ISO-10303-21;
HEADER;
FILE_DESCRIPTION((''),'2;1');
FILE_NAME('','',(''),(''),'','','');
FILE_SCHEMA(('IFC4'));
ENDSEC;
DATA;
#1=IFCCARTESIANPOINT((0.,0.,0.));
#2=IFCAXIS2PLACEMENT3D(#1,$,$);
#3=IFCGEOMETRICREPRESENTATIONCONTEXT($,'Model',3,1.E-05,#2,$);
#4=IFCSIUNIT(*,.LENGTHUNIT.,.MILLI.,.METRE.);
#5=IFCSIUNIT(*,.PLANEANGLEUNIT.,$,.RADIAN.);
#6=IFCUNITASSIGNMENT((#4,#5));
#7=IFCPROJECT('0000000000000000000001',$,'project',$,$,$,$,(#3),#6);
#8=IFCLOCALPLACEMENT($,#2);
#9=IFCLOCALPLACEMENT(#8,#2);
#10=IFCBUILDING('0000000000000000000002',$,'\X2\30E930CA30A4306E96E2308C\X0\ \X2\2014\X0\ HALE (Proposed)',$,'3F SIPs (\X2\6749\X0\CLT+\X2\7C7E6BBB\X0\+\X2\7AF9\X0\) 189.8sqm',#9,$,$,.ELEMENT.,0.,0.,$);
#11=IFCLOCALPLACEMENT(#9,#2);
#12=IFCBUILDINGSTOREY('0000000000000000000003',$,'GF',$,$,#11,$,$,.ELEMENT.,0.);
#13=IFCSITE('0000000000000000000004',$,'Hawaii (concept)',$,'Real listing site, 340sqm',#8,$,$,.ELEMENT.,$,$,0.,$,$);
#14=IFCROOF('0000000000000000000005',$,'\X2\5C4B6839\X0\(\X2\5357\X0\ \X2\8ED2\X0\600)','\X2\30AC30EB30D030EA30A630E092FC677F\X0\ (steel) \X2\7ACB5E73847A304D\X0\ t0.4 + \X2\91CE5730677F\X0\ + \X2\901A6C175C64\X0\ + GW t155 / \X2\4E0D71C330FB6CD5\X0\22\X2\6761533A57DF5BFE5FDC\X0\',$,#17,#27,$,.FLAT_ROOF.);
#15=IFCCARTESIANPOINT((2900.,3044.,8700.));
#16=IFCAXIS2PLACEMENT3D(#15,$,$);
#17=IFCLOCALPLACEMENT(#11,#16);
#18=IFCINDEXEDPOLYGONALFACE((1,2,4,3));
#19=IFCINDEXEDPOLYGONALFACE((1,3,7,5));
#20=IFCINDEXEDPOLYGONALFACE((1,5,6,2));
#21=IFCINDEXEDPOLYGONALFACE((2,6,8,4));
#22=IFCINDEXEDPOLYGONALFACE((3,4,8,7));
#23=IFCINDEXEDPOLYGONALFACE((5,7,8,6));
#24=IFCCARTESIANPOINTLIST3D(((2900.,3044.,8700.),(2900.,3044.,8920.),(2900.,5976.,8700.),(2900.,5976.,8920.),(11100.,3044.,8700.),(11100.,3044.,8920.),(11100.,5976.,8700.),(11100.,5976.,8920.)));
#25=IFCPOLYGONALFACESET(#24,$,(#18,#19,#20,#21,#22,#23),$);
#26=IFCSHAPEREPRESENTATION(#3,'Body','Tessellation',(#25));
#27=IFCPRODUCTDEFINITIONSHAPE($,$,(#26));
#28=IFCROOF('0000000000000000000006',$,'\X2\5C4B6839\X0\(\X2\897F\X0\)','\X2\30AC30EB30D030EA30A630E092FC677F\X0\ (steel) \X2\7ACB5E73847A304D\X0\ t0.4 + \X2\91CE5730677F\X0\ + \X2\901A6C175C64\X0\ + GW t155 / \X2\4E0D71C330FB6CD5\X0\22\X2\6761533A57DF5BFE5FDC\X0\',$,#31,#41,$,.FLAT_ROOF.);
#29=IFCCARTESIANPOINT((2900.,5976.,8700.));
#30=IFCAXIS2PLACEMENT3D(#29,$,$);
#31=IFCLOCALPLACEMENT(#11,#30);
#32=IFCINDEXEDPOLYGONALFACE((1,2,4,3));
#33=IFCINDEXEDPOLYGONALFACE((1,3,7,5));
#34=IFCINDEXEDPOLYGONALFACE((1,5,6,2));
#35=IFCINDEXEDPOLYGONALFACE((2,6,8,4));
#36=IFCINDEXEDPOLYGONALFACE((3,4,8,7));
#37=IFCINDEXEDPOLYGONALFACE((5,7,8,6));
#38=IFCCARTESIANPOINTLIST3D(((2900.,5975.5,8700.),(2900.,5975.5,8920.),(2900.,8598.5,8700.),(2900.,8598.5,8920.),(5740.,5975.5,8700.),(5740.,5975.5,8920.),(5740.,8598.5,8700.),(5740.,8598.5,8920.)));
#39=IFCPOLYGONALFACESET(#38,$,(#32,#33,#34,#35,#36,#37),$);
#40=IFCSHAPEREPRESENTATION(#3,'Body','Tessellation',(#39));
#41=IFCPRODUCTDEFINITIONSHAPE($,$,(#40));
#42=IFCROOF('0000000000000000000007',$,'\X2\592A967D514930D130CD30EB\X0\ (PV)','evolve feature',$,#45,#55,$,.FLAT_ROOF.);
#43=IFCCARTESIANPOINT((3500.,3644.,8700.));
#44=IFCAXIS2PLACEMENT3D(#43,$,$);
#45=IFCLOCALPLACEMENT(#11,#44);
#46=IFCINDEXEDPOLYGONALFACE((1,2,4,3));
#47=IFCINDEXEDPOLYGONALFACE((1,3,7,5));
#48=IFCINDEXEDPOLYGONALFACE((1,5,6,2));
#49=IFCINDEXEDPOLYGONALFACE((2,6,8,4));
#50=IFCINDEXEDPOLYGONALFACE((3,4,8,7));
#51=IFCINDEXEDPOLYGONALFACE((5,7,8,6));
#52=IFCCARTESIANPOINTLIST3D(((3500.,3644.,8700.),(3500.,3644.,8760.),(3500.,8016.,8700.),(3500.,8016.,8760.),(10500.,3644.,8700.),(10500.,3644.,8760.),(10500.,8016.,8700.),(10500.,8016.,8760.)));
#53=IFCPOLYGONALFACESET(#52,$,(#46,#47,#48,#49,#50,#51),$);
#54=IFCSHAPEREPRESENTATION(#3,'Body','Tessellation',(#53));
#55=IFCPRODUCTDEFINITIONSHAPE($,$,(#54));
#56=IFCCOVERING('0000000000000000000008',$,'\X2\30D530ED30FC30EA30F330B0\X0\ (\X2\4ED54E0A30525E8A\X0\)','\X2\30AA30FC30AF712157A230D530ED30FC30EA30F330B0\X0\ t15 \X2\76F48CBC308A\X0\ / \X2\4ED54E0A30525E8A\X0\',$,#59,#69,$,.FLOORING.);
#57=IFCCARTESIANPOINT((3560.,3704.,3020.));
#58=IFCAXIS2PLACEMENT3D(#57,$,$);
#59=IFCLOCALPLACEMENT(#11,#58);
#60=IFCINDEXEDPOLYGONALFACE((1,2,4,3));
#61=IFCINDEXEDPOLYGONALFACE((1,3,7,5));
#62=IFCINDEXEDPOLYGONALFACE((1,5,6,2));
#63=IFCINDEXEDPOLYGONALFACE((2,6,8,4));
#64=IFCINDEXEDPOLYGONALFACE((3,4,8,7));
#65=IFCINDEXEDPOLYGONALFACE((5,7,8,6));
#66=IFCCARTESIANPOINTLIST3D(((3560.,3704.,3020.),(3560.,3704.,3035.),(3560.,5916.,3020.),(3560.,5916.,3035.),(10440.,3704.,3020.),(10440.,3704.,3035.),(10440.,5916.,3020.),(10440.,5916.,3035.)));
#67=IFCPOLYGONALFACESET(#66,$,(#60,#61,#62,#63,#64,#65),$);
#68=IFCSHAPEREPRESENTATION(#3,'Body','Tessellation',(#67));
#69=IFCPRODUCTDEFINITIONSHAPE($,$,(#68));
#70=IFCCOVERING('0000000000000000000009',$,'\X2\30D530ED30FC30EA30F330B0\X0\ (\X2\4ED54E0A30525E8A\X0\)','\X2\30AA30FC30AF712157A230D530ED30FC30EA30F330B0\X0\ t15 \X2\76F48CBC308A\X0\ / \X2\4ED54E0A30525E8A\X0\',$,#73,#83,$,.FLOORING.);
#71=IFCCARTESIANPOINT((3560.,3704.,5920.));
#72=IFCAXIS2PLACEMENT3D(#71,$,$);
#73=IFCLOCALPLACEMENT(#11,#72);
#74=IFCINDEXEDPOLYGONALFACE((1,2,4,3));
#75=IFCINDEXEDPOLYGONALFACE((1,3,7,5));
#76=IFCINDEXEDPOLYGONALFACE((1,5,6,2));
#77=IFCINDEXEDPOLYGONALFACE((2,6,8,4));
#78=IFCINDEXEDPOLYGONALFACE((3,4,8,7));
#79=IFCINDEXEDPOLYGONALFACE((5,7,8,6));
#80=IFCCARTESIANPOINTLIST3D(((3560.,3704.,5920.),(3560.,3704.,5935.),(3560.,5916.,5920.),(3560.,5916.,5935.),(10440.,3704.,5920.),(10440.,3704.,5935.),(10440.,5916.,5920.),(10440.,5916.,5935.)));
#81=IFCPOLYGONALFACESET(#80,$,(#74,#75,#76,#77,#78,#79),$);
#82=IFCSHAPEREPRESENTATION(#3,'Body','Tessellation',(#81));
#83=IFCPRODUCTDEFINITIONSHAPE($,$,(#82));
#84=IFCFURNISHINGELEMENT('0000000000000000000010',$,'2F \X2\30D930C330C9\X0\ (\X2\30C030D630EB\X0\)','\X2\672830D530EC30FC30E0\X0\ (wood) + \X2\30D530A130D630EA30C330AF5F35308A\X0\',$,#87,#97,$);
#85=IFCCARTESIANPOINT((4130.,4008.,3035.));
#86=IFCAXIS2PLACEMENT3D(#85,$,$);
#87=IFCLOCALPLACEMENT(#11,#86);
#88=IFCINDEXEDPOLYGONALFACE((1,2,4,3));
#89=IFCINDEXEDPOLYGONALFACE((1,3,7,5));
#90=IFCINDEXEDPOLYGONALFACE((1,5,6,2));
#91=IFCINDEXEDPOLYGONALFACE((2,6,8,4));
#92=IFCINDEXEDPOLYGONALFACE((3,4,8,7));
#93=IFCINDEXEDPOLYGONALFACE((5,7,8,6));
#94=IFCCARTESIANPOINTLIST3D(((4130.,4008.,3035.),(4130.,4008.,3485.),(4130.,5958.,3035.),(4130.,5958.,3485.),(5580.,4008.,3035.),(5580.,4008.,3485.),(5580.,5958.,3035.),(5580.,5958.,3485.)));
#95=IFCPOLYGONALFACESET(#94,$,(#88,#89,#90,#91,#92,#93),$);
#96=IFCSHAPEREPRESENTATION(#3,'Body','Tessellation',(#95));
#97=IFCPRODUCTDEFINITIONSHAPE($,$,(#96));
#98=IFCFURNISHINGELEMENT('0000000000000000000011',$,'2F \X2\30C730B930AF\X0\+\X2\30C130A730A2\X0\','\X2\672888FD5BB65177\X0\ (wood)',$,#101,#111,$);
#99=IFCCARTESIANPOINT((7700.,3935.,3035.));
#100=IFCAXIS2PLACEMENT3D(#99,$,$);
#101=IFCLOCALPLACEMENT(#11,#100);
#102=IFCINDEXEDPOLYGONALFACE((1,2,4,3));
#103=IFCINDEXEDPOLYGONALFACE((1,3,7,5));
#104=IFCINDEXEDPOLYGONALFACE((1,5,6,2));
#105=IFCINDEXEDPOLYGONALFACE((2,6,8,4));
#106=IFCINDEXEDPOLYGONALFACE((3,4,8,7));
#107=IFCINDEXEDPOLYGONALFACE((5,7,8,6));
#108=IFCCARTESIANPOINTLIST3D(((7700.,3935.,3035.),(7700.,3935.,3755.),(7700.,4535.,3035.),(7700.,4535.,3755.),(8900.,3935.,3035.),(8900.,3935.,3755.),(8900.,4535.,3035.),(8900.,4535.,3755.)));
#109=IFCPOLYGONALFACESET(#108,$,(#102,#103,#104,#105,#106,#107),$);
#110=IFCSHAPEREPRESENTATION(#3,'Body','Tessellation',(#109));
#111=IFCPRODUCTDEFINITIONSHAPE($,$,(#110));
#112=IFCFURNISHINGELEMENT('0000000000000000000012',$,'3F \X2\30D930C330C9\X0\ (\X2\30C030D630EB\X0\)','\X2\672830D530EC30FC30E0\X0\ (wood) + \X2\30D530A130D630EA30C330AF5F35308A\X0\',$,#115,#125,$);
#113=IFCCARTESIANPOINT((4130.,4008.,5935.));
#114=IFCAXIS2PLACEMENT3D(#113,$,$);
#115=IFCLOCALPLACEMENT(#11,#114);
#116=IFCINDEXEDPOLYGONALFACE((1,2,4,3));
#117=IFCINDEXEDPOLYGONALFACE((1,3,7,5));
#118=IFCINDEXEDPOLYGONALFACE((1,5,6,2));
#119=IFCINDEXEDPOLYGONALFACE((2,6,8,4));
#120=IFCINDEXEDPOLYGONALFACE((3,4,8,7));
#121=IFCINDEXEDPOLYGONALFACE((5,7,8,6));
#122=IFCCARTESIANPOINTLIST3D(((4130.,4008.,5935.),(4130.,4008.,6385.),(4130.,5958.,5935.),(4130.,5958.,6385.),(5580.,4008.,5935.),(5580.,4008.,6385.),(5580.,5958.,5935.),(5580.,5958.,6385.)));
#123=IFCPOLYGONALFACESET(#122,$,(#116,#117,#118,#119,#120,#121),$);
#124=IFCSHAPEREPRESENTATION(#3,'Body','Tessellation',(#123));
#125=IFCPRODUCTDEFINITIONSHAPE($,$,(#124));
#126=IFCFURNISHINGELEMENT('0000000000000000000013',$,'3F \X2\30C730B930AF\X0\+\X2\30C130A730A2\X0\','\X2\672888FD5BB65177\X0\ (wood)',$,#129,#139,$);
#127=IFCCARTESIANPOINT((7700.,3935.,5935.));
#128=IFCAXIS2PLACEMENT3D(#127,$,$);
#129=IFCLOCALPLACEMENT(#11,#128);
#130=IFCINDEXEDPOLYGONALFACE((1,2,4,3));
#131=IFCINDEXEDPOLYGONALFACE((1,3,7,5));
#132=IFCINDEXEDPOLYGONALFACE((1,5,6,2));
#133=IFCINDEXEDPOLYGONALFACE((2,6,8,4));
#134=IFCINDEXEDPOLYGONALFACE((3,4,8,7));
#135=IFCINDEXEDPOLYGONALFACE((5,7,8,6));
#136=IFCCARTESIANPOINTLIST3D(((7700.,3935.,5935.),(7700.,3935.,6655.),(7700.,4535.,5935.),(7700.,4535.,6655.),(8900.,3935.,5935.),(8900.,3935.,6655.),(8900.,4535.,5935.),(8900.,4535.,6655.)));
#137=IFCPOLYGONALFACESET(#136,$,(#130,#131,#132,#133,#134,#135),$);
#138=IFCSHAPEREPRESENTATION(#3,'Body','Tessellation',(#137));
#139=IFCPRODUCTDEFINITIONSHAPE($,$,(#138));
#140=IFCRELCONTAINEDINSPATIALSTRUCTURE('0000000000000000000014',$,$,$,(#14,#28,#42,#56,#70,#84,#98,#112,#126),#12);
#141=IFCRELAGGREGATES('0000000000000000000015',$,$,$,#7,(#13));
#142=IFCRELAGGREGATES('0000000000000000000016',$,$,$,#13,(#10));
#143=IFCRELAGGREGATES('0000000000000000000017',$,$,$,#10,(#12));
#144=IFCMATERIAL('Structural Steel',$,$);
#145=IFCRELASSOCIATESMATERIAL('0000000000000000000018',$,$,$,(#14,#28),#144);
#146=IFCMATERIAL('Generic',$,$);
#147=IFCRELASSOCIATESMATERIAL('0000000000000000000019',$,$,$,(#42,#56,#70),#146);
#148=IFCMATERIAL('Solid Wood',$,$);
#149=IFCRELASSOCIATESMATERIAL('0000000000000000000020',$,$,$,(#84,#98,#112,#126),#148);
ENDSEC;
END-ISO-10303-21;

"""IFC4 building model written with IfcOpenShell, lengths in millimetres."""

from ifc_helpers import new_model, si_unit, frame, frame_2d, origin, place, context, project, spatial, rectangle, extrude, material, element, save


model = new_model("IFC4")

# Units and contexts
model_context = context("Model", 3, precision=1e-05, world=origin())
ifc_project = project(units=[si_unit("LENGTHUNIT", "METRE", prefix="MILLI"), si_unit("PLANEANGLEUNIT", "RADIAN")], contexts=[model_context])

# Site, building, storey
site_placement = place(None, origin())
site = spatial("IfcSite", under=ifc_project, at=site_placement, Name="Hawaii (concept)", ObjectType="Real listing site, 340sqm", CompositionType="ELEMENT", RefElevation=0.0)
building_placement = place(site_placement, origin())
building = spatial("IfcBuilding", under=site, at=building_placement, Name="ラナイの離れ — HALE (Proposed)", ObjectType="3F SIPs (杉CLT+籾殻+竹) 189.8sqm", CompositionType="ELEMENT", ElevationOfRefHeight=0.0, ElevationOfTerrain=0.0)
storey_placement = place(building_placement, origin())
storey = spatial("IfcBuildingStorey", under=building, at=storey_placement, Name="GF", CompositionType="ELEMENT", Elevation=0.0)

# Shared definitions
ifc_material_1 = material(Name="Solid Wood")

# Roofs
ifc_material_2 = material(Name="Structural Steel")
roof_1_placement = place(storey_placement, frame((2900.0, 3044.0, 8700.0)))
element("IfcRoof", 1, at=roof_1_placement, inside=storey, material=ifc_material_2, Name="屋根(南 軒600)", Description="ガルバリウム鋼板 (steel) 立平葺き t0.4 + 野地板 + 通気層 + GW t155 / 不燃・法22条区域対応", PredefinedType="FLAT_ROOF", context=model_context, shape_type="SweptSolid", body=[
    extrude(rectangle(XDim=8200.0, YDim=2932.0, at=frame_2d((4100.0, 1466.0))), frame((2900.0, 3044.0, 8700.0)), (0.0, 0.0, 1.0), 220.0),
])
roof_2_placement = place(storey_placement, frame((2900.0, 5976.0, 8700.0)))
element("IfcRoof", 2, at=roof_2_placement, inside=storey, material=ifc_material_2, Name="屋根(西)", Description="ガルバリウム鋼板 (steel) 立平葺き t0.4 + 野地板 + 通気層 + GW t155 / 不燃・法22条区域対応", PredefinedType="FLAT_ROOF", context=model_context, shape_type="SweptSolid", body=[
    extrude(rectangle(XDim=2840.0, YDim=2623.0, at=frame_2d((1420.0, 1311.0))), frame((2900.0, 5976.0, 8700.0)), (0.0, 0.0, 1.0), 220.0),
])
ifc_material_3 = material(Name="Generic")
roof_3_placement = place(storey_placement, frame((3500.0, 3644.0, 8700.0)))
element("IfcRoof", 3, at=roof_3_placement, inside=storey, material=ifc_material_3, Name="太陽光パネル (PV)", Description="evolve feature", PredefinedType="FLAT_ROOF", context=model_context, shape_type="SweptSolid", body=[
    extrude(rectangle(XDim=7000.0, YDim=4372.0, at=frame_2d((3500.0, 2186.0))), frame((3500.0, 3644.0, 8700.0)), (0.0, 0.0, 1.0), 60.0),
])

# Coverings
covering_1_placement = place(storey_placement, frame((3560.0, 3704.0, 3020.0)))
element("IfcCovering", 4, at=covering_1_placement, inside=storey, material=ifc_material_3, Name="フローリング (仕上げ床)", Description="オーク無垢フローリング t15 直貼り / 仕上げ床", PredefinedType="FLOORING", context=model_context, shape_type="SweptSolid", body=[
    extrude(rectangle(XDim=6880.0, YDim=2212.0, at=frame_2d((3440.0, 1106.0))), frame((3560.0, 3704.0, 3020.0)), (0.0, 0.0, 1.0), 15.0),
])
covering_2_placement = place(storey_placement, frame((3560.0, 3704.0, 5920.0)))
element("IfcCovering", 5, at=covering_2_placement, inside=storey, material=ifc_material_3, Name="フローリング (仕上げ床)", Description="オーク無垢フローリング t15 直貼り / 仕上げ床", PredefinedType="FLOORING", context=model_context, shape_type="SweptSolid", body=[
    extrude(rectangle(XDim=6880.0, YDim=2212.0, at=frame_2d((3440.0, 1106.0))), frame((3560.0, 3704.0, 5920.0)), (0.0, 0.0, 1.0), 15.0),
])

# Furnishing elements
furnishing_1_placement = place(storey_placement, frame((4130.0, 4008.0, 3035.0)))
element("IfcFurnishingElement", 6, at=furnishing_1_placement, inside=storey, material=ifc_material_1, Name="2F ベッド (ダブル)", Description="木フレーム (wood) + ファブリック張り", context=model_context, shape_type="SweptSolid", body=[
    extrude(rectangle(XDim=1450.0, YDim=1950.0, at=frame_2d((725.0, 975.0))), frame((4130.0, 4008.0, 3035.0)), (0.0, 0.0, 1.0), 450.0),
])
furnishing_2_placement = place(storey_placement, frame((7700.0, 3935.0, 3035.0)))
element("IfcFurnishingElement", 7, at=furnishing_2_placement, inside=storey, material=ifc_material_1, Name="2F デスク+チェア", Description="木製家具 (wood)", context=model_context, shape_type="SweptSolid", body=[
    extrude(rectangle(XDim=1200.0, YDim=600.0, at=frame_2d((600.0, 300.0))), frame((7700.0, 3935.0, 3035.0)), (0.0, 0.0, 1.0), 720.0),
])
furnishing_3_placement = place(storey_placement, frame((4130.0, 4008.0, 5935.0)))
element("IfcFurnishingElement", 8, at=furnishing_3_placement, inside=storey, material=ifc_material_1, Name="3F ベッド (ダブル)", Description="木フレーム (wood) + ファブリック張り", context=model_context, shape_type="SweptSolid", body=[
    extrude(rectangle(XDim=1450.0, YDim=1950.0, at=frame_2d((725.0, 975.0))), frame((4130.0, 4008.0, 5935.0)), (0.0, 0.0, 1.0), 450.0),
])
furnishing_4_placement = place(storey_placement, frame((7700.0, 3935.0, 5935.0)))
element("IfcFurnishingElement", 9, at=furnishing_4_placement, inside=storey, material=ifc_material_1, Name="3F デスク+チェア", Description="木製家具 (wood)", context=model_context, shape_type="SweptSolid", body=[
    extrude(rectangle(XDim=1200.0, YDim=600.0, at=frame_2d((600.0, 300.0))), frame((7700.0, 3935.0, 5935.0)), (0.0, 0.0, 1.0), 720.0),
])

save(model, "model.ifc")
